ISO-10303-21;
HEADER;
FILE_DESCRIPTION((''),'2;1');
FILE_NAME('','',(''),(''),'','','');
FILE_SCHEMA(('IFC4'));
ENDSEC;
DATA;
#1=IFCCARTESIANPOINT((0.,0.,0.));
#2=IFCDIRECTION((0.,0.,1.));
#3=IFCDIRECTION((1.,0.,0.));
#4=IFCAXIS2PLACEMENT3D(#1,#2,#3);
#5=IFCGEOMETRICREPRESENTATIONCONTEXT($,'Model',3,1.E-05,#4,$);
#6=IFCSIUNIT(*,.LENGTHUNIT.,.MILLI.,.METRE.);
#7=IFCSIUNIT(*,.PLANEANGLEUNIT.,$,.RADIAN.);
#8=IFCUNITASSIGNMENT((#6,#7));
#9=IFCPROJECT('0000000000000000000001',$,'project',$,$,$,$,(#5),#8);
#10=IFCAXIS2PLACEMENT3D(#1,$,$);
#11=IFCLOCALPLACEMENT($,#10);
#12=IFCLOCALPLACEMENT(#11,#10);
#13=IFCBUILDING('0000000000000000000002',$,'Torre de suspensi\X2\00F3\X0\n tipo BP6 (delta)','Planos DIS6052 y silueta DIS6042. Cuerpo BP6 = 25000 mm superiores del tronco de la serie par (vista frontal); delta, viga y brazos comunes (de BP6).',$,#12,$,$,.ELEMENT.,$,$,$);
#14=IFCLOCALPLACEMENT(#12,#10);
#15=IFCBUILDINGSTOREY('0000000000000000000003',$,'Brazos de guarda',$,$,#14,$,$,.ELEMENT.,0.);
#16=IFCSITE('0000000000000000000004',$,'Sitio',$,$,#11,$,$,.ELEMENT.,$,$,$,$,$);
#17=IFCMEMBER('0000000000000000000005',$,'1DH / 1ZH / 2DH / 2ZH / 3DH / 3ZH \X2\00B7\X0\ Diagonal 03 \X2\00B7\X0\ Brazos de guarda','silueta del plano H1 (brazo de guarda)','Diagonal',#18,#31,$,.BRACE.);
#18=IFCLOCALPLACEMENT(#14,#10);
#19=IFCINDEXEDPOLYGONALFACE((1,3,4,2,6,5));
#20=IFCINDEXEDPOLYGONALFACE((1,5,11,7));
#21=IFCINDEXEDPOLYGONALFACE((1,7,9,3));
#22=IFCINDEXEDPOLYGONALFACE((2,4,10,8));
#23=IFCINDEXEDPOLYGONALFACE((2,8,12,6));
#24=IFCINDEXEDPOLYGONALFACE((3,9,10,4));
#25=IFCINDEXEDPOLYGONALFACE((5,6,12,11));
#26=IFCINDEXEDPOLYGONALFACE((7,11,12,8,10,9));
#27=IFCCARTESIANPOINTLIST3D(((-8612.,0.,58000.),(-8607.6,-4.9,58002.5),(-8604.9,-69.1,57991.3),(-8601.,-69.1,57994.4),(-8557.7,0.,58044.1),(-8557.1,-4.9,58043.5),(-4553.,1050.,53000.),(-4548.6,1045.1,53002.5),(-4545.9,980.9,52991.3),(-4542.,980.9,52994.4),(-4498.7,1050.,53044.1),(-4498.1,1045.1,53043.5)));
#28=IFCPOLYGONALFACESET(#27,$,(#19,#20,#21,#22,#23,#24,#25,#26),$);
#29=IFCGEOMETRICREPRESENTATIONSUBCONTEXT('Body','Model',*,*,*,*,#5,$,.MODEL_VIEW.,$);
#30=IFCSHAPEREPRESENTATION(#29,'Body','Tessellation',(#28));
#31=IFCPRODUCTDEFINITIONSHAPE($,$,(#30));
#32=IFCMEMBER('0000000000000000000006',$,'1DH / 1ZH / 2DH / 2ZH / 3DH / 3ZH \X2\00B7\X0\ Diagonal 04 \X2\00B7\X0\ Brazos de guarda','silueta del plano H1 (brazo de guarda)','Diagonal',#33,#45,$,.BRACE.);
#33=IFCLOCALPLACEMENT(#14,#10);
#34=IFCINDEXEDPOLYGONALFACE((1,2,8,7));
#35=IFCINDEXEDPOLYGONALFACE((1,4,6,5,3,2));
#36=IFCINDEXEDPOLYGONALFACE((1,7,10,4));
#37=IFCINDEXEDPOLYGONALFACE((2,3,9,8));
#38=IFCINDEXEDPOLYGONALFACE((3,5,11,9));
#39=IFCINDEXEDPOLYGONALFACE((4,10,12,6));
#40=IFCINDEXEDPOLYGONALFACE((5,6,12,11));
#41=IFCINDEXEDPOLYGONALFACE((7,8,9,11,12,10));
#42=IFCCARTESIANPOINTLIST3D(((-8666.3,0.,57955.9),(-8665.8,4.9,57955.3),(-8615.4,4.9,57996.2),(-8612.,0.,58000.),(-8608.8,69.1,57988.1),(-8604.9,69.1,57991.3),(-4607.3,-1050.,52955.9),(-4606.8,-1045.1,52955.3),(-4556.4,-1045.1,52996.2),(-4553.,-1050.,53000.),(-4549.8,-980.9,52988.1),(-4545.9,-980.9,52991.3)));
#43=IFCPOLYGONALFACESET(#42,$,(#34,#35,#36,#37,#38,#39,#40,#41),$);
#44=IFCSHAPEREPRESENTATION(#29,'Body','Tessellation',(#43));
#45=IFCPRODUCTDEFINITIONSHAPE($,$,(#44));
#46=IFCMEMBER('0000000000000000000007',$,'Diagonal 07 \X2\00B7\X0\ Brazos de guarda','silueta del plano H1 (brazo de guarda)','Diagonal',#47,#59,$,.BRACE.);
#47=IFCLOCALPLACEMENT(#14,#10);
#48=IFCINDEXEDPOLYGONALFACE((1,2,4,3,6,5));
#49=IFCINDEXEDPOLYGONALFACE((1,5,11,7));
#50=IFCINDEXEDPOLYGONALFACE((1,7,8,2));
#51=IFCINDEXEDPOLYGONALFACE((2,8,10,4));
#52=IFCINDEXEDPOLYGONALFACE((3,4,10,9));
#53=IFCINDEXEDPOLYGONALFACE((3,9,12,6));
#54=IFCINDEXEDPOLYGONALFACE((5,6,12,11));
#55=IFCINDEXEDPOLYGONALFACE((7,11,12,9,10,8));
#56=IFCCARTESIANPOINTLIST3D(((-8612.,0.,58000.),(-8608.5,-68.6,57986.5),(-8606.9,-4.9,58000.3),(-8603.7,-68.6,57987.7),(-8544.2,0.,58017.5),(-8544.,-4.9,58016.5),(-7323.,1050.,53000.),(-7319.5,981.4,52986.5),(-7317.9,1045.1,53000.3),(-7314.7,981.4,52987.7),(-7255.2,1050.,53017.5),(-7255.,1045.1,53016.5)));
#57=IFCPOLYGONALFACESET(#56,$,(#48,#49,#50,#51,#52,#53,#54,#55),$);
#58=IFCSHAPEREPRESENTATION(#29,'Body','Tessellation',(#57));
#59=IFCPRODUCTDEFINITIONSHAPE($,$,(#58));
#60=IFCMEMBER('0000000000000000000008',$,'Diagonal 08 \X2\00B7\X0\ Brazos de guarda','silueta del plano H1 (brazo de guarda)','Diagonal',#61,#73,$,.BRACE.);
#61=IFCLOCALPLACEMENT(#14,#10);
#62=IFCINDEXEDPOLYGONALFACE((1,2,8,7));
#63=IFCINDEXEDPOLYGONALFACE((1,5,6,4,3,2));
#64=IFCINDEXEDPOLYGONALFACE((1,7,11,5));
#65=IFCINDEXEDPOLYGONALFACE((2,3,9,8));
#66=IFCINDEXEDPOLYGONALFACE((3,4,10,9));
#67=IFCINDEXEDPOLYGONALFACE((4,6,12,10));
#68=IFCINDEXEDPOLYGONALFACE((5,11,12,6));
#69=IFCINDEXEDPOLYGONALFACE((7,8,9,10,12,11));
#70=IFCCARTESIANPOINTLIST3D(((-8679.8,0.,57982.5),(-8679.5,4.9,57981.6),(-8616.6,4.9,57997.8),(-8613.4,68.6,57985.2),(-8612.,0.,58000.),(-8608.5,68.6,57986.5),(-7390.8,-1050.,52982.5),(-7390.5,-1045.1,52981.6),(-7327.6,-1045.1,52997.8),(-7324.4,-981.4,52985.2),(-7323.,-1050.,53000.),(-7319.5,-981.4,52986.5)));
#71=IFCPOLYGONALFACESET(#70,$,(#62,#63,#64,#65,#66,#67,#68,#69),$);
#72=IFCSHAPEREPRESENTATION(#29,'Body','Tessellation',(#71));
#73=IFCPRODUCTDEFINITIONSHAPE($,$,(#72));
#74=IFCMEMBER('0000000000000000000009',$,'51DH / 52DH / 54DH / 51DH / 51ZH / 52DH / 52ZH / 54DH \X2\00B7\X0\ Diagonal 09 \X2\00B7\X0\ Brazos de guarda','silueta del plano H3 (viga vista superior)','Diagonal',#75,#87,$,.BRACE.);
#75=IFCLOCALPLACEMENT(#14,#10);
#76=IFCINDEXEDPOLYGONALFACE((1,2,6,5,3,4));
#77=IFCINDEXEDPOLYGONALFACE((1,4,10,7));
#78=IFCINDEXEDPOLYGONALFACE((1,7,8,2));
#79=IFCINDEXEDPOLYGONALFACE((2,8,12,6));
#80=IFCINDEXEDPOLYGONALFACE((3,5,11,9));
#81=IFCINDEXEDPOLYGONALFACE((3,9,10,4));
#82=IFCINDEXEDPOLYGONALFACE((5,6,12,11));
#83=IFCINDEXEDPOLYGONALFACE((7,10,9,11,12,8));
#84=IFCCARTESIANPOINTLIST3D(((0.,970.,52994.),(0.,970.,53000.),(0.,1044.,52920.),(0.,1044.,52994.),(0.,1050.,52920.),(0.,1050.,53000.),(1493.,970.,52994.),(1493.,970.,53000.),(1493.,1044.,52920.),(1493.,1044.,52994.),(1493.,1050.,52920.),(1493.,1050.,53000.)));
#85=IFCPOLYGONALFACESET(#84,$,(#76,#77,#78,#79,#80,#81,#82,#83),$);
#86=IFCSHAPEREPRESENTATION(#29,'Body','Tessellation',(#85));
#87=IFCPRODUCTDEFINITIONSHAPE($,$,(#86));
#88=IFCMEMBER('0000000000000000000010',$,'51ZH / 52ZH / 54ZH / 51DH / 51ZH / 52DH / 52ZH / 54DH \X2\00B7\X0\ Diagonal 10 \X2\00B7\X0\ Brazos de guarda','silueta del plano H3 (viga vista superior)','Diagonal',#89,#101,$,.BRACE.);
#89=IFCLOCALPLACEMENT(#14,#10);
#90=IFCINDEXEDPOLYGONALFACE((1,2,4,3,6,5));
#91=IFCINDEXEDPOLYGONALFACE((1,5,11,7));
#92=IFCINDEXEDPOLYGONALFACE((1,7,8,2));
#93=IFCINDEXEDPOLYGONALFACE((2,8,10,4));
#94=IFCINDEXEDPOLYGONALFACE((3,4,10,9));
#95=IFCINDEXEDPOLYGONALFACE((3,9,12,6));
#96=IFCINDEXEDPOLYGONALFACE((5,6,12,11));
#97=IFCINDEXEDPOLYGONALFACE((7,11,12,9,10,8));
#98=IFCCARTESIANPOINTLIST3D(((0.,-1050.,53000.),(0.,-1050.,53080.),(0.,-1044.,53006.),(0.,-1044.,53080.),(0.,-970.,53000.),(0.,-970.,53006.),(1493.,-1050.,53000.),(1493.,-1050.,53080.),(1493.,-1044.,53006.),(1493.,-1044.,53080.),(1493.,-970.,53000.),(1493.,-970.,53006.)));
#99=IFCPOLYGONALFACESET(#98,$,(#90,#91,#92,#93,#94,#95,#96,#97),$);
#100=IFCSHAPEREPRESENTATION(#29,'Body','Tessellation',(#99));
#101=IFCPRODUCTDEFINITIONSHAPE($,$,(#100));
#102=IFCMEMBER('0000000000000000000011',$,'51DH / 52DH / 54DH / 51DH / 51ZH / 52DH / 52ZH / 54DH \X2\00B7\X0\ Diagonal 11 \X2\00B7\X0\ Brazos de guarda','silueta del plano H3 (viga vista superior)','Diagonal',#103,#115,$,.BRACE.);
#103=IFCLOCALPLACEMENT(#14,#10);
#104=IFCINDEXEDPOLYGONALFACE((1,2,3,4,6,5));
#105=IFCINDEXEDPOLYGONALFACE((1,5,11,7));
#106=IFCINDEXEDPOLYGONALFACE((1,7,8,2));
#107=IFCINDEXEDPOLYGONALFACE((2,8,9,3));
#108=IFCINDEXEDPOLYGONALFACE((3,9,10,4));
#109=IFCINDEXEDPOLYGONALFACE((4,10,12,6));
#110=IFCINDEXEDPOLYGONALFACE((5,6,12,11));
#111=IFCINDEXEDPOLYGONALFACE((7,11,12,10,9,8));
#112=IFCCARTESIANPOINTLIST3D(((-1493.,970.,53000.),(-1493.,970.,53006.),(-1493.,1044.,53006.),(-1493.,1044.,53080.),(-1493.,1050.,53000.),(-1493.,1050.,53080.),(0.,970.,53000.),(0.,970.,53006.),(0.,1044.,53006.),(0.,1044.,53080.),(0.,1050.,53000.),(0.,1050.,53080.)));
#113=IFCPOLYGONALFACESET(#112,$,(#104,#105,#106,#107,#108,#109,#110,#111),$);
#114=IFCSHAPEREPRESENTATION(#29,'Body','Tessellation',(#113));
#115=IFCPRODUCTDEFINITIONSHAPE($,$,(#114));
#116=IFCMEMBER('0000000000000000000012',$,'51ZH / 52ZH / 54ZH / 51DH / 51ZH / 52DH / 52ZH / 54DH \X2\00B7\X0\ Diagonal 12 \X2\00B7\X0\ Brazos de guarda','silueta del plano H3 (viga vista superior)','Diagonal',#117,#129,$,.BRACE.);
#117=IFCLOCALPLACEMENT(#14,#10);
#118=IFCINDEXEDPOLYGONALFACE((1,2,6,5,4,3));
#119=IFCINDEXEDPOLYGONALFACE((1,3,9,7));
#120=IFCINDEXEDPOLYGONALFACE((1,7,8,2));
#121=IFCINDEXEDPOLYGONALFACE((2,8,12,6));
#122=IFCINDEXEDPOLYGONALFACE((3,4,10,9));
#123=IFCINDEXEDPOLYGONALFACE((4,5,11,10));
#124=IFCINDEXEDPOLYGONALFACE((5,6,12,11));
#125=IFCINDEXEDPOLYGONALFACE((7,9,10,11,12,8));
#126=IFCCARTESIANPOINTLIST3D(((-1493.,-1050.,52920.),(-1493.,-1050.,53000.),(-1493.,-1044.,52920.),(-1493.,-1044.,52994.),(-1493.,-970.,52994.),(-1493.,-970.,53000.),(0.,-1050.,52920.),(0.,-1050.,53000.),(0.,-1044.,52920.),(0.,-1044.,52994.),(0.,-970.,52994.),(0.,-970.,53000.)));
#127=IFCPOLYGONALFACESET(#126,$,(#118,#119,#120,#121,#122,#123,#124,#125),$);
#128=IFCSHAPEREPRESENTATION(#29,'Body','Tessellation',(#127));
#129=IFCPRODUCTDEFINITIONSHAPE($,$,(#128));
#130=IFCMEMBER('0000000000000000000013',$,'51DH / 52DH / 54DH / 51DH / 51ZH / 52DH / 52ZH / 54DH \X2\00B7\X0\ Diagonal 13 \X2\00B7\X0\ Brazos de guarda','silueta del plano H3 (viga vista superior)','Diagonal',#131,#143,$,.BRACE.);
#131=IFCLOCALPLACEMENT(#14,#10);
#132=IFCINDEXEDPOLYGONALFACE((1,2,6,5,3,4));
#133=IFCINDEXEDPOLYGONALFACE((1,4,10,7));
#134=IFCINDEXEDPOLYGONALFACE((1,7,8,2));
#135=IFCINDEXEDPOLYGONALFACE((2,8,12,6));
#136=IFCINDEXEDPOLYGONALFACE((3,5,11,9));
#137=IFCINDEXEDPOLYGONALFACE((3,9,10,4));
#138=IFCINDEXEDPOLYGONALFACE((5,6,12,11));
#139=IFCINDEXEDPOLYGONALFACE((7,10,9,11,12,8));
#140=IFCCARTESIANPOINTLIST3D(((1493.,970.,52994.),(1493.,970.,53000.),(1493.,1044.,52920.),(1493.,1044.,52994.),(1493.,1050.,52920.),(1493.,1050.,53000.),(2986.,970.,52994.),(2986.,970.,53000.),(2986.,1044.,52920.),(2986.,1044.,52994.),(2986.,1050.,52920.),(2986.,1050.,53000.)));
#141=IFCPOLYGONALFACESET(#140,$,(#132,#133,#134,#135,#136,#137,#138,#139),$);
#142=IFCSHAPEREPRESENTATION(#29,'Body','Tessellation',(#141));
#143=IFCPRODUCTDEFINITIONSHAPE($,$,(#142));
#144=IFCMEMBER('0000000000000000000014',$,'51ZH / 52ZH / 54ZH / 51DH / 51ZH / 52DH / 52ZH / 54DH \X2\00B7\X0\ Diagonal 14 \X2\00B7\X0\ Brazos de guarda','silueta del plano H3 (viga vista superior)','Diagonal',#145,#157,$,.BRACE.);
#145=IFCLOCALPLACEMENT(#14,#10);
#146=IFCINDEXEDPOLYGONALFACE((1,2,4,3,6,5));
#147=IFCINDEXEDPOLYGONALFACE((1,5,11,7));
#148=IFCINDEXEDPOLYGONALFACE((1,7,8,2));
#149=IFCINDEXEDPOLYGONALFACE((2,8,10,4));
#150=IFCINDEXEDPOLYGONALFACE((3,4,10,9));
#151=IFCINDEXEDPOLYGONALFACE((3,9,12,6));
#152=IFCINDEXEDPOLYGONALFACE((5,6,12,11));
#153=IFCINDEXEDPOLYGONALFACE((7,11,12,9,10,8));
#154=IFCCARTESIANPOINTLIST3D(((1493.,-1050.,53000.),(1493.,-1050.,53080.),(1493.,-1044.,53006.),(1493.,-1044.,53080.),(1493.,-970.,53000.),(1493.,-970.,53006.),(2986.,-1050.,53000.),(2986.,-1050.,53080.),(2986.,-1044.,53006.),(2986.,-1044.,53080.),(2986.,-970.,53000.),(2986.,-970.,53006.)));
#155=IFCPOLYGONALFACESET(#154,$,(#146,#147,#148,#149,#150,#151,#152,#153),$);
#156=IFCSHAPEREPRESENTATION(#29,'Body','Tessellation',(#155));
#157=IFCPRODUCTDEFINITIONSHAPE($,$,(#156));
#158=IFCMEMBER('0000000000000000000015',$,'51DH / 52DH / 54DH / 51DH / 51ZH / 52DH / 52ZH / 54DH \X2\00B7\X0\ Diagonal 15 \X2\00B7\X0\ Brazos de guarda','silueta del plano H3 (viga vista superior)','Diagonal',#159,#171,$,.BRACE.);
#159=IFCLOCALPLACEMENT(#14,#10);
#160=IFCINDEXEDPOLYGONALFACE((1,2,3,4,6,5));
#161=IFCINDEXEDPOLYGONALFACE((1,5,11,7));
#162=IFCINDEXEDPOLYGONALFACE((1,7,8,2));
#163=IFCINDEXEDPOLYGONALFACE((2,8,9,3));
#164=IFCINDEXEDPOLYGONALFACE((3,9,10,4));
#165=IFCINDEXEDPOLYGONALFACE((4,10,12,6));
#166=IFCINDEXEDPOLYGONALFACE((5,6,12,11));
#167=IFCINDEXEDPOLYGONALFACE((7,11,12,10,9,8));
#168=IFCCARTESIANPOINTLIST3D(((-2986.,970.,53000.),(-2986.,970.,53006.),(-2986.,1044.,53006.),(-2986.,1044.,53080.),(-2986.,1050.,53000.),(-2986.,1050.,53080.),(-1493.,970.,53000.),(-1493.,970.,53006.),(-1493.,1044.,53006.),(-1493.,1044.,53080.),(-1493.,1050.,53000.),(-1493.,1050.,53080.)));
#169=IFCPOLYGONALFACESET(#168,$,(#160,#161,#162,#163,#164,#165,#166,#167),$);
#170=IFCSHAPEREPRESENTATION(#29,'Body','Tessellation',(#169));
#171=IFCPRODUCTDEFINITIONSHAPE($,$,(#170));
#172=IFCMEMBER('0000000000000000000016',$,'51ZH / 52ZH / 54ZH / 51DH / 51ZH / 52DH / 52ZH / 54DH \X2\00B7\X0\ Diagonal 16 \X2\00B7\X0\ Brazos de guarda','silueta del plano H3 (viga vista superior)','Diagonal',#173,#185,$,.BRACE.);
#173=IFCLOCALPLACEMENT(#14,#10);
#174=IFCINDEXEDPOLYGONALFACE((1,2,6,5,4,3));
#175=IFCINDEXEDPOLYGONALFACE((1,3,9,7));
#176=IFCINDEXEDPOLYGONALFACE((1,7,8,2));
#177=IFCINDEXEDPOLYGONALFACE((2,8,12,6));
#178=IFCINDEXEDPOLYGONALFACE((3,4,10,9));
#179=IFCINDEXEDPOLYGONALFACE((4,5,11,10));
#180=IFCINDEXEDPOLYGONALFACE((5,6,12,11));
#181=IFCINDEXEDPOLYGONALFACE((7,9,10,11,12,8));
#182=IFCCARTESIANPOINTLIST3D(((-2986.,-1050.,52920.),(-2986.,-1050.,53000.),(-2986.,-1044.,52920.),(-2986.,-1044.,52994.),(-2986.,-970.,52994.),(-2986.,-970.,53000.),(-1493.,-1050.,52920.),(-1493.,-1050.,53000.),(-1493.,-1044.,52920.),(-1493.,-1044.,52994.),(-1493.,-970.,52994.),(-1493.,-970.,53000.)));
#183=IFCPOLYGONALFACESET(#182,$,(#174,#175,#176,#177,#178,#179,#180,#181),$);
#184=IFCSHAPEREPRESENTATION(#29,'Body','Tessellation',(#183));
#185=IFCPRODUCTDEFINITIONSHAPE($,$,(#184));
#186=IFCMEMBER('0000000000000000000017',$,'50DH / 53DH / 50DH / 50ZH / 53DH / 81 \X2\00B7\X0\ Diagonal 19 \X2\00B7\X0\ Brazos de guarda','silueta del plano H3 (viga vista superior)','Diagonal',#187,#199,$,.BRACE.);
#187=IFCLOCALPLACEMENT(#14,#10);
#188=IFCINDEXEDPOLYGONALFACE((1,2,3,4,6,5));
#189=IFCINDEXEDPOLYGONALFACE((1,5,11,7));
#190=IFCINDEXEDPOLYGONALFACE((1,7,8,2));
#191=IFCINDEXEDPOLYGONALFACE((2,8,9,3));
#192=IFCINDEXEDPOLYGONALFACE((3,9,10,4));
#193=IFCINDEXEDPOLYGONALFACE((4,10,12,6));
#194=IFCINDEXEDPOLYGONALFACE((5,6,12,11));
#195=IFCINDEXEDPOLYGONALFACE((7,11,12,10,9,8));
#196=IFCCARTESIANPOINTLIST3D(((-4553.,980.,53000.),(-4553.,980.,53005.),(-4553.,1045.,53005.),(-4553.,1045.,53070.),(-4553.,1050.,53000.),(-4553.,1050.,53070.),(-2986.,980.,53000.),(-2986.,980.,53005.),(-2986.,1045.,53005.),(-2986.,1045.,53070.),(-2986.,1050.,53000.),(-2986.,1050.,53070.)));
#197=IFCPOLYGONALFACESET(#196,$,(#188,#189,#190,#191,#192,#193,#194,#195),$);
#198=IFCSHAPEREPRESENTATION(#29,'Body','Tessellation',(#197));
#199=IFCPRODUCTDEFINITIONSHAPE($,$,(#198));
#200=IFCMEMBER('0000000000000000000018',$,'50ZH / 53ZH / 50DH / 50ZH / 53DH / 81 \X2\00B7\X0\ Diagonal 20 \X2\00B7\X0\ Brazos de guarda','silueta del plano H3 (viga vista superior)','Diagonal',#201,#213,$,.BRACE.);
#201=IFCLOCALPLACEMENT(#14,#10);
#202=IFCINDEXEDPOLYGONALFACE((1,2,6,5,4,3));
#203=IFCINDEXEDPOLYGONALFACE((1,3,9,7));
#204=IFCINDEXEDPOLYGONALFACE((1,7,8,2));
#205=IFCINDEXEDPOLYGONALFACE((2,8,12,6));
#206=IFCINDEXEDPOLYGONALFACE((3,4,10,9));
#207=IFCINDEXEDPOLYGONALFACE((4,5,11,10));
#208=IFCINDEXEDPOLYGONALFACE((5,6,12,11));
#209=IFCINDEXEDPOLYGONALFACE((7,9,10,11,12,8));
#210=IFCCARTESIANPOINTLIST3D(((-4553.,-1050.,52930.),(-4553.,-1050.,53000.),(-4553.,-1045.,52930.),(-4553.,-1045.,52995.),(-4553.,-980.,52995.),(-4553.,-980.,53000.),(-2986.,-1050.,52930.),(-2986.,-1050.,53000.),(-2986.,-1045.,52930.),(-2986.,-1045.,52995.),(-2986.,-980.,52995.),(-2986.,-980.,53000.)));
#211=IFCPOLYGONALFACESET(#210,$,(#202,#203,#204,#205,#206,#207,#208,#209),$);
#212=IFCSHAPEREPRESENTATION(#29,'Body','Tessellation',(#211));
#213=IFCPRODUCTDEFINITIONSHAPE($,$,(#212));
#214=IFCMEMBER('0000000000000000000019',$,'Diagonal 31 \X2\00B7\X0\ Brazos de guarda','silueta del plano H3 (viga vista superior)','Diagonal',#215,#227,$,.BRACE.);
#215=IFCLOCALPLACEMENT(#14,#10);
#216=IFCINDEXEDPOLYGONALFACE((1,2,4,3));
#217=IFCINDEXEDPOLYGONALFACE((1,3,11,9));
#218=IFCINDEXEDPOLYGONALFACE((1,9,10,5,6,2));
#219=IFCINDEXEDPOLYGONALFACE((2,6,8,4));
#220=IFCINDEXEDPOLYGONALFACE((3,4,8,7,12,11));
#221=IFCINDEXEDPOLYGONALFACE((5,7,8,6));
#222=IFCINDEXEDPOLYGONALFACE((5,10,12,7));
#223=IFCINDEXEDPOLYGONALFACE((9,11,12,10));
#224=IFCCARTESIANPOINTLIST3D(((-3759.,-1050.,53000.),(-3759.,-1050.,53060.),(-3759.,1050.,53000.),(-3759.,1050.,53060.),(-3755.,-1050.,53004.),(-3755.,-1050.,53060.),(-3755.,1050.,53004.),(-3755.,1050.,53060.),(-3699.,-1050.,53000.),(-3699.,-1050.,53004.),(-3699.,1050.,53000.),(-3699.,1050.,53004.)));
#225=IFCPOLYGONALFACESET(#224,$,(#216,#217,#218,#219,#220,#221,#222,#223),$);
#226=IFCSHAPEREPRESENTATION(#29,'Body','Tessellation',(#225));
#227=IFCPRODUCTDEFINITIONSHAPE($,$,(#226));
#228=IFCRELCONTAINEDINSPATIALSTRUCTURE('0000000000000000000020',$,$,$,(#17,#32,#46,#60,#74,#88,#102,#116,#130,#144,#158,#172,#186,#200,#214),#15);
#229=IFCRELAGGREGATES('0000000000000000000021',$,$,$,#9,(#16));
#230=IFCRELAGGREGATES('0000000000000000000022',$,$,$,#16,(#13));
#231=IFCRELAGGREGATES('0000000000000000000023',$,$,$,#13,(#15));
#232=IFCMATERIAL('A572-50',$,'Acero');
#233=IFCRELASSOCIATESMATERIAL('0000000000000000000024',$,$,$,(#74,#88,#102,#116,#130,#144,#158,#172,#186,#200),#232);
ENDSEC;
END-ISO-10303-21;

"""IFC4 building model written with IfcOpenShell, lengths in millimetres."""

from ifc_helpers import new_model, si_unit, frame, frame_2d, origin, origin_with_axes, place, context, subcontext, project, spatial, l_section, extrude, material, element, save


model = new_model("IFC4")

# Units and contexts
model_context = context("Model", 3, precision=1e-05, world=origin_with_axes())
body_context = subcontext(model_context, "Body", "Model", "MODEL_VIEW")
ifc_project = project(units=[si_unit("LENGTHUNIT", "METRE", prefix="MILLI"), si_unit("PLANEANGLEUNIT", "RADIAN")], contexts=[model_context])

# Site, building, storey
site_placement = place(None, origin())
site = spatial("IfcSite", under=ifc_project, at=site_placement, Name="Sitio", CompositionType="ELEMENT")
building_placement = place(site_placement, origin())
building = spatial("IfcBuilding", under=site, at=building_placement, Name="Torre de suspensión tipo BP6 (delta)", Description="Planos DIS6052 y silueta DIS6042. Cuerpo BP6 = 25000 mm superiores del tronco de la serie par (vista frontal); delta, viga y brazos comunes (de BP6).", CompositionType="ELEMENT")
storey_placement = place(building_placement, origin())
storey = spatial("IfcBuildingStorey", under=building, at=storey_placement, Name="Brazos de guarda", CompositionType="ELEMENT", Elevation=0.0)

# Members
for number, where, z_axis, x_axis, name in (
    (1, (-4553.0, 1050.0, 53000.0), (-0.622052, -0.160915, 0.766262), (0.101419, -0.986968, -0.124931), "1DH / 1ZH / 2DH / 2ZH / 3DH / 3ZH · Diagonal 03 · Brazos de guarda"),
    (2, (-4553.0, -1050.0, 53000.0), (-0.622052, 0.160915, 0.766262), (0.101419, 0.986968, -0.124931), "1DH / 1ZH / 2DH / 2ZH / 3DH / 3ZH · Diagonal 04 · Brazos de guarda"),
):
    element("IfcMember", number, at=place(storey_placement, frame(where, z_axis=z_axis, x_axis=x_axis)), inside=storey, Name=name, Description="silueta del plano H1 (brazo de guarda)", ObjectType="Diagonal", PredefinedType="BRACE", context=body_context, shape_type="SweptSolid", body=[
        extrude(l_section(Depth=70.0, Width=70.0, Thickness=5.0, at=frame_2d((35.0, 35.0))), None, (0.0, 0.0, 1.0), 6525.2),
    ])
for number, where, z_axis, x_axis, name in (
    (3, (-7323.0, 1050.0, 53000.0), (-0.244631, -0.199273, 0.948918), (0.049746, -0.979944, -0.192964), "Diagonal 07 · Brazos de guarda"),
    (4, (-7323.0, -1050.0, 53000.0), (-0.244631, 0.199273, 0.948918), (0.049746, 0.979944, -0.192964), "Diagonal 08 · Brazos de guarda"),
):
    element("IfcMember", number, at=place(storey_placement, frame(where, z_axis=z_axis, x_axis=x_axis)), inside=storey, Name=name, Description="silueta del plano H1 (brazo de guarda)", ObjectType="Diagonal", PredefinedType="BRACE", context=body_context, shape_type="SweptSolid", body=[
        extrude(l_section(Depth=70.0, Width=70.0, Thickness=5.0, at=frame_2d((35.0, 35.0))), None, (0.0, 0.0, 1.0), 5269.2),
    ])
ifc_material_1 = material(Name="A572-50", Category="Acero")
for number, where, z_axis, x_axis, name in (
    (5, (0.0, 1050.0, 53000.0), (1.0, 0.0, 0.0), (0.0, -1.0, 0.0), "51DH / 52DH / 54DH / 51DH / 51ZH / 52DH / 52ZH / 54DH · Diagonal 09 · Brazos de guarda"),
    (6, (0.0, -1050.0, 53000.0), (1.0, 0.0, 0.0), (0.0, 1.0, 0.0), "51ZH / 52ZH / 54ZH / 51DH / 51ZH / 52DH / 52ZH / 54DH · Diagonal 10 · Brazos de guarda"),
    (7, (0.0, 1050.0, 53000.0), (-1.0, 0.0, 0.0), (0.0, -1.0, 0.0), "51DH / 52DH / 54DH / 51DH / 51ZH / 52DH / 52ZH / 54DH · Diagonal 11 · Brazos de guarda"),
    (8, (0.0, -1050.0, 53000.0), (-1.0, 0.0, 0.0), (0.0, 1.0, 0.0), "51ZH / 52ZH / 54ZH / 51DH / 51ZH / 52DH / 52ZH / 54DH · Diagonal 12 · Brazos de guarda"),
    (9, (1493.0, 1050.0, 53000.0), (1.0, 0.0, 0.0), (0.0, -1.0, 0.0), "51DH / 52DH / 54DH / 51DH / 51ZH / 52DH / 52ZH / 54DH · Diagonal 13 · Brazos de guarda"),
    (10, (1493.0, -1050.0, 53000.0), (1.0, 0.0, 0.0), (0.0, 1.0, 0.0), "51ZH / 52ZH / 54ZH / 51DH / 51ZH / 52DH / 52ZH / 54DH · Diagonal 14 · Brazos de guarda"),
    (11, (-1493.0, 1050.0, 53000.0), (-1.0, 0.0, 0.0), (0.0, -1.0, 0.0), "51DH / 52DH / 54DH / 51DH / 51ZH / 52DH / 52ZH / 54DH · Diagonal 15 · Brazos de guarda"),
    (12, (-1493.0, -1050.0, 53000.0), (-1.0, 0.0, 0.0), (0.0, 1.0, 0.0), "51ZH / 52ZH / 54ZH / 51DH / 51ZH / 52DH / 52ZH / 54DH · Diagonal 16 · Brazos de guarda"),
):
    element("IfcMember", number, at=place(storey_placement, frame(where, z_axis=z_axis, x_axis=x_axis)), inside=storey, material=ifc_material_1, Name=name, Description="silueta del plano H3 (viga vista superior)", ObjectType="Diagonal", PredefinedType="BRACE", context=body_context, shape_type="SweptSolid", body=[
        extrude(l_section(Depth=80.0, Width=80.0, Thickness=6.0, at=frame_2d((40.0, 40.0))), None, (0.0, 0.0, 1.0), 1493.0),
    ])
for number, where, z_axis, x_axis, name in (
    (13, (-2986.0, 1050.0, 53000.0), (-1.0, 0.0, 0.0), (0.0, -1.0, 0.0), "50DH / 53DH / 50DH / 50ZH / 53DH / 81 · Diagonal 19 · Brazos de guarda"),
    (14, (-2986.0, -1050.0, 53000.0), (-1.0, 0.0, 0.0), (0.0, 1.0, 0.0), "50ZH / 53ZH / 50DH / 50ZH / 53DH / 81 · Diagonal 20 · Brazos de guarda"),
):
    element("IfcMember", number, at=place(storey_placement, frame(where, z_axis=z_axis, x_axis=x_axis)), inside=storey, material=ifc_material_1, Name=name, Description="silueta del plano H3 (viga vista superior)", ObjectType="Diagonal", PredefinedType="BRACE", context=body_context, shape_type="SweptSolid", body=[
        extrude(l_section(Depth=70.0, Width=70.0, Thickness=5.0, at=frame_2d((35.0, 35.0))), None, (0.0, 0.0, 1.0), 1567.0),
    ])
for number, where, z_axis, x_axis, name in (
    (15, (-3759.0, 1050.0, 53000.0), (0.0, -1.0, 0.0), (1.0, 0.0, 0.0), "Diagonal 31 · Brazos de guarda"),
):
    element("IfcMember", number, at=place(storey_placement, frame(where, z_axis=z_axis, x_axis=x_axis)), inside=storey, Name=name, Description="silueta del plano H3 (viga vista superior)", ObjectType="Diagonal", PredefinedType="BRACE", context=body_context, shape_type="SweptSolid", body=[
        extrude(l_section(Depth=60.0, Width=60.0, Thickness=4.0, at=frame_2d((30.0, 30.0))), None, (0.0, 0.0, 1.0), 2100.0),
    ])

save(model, "model.ifc")
